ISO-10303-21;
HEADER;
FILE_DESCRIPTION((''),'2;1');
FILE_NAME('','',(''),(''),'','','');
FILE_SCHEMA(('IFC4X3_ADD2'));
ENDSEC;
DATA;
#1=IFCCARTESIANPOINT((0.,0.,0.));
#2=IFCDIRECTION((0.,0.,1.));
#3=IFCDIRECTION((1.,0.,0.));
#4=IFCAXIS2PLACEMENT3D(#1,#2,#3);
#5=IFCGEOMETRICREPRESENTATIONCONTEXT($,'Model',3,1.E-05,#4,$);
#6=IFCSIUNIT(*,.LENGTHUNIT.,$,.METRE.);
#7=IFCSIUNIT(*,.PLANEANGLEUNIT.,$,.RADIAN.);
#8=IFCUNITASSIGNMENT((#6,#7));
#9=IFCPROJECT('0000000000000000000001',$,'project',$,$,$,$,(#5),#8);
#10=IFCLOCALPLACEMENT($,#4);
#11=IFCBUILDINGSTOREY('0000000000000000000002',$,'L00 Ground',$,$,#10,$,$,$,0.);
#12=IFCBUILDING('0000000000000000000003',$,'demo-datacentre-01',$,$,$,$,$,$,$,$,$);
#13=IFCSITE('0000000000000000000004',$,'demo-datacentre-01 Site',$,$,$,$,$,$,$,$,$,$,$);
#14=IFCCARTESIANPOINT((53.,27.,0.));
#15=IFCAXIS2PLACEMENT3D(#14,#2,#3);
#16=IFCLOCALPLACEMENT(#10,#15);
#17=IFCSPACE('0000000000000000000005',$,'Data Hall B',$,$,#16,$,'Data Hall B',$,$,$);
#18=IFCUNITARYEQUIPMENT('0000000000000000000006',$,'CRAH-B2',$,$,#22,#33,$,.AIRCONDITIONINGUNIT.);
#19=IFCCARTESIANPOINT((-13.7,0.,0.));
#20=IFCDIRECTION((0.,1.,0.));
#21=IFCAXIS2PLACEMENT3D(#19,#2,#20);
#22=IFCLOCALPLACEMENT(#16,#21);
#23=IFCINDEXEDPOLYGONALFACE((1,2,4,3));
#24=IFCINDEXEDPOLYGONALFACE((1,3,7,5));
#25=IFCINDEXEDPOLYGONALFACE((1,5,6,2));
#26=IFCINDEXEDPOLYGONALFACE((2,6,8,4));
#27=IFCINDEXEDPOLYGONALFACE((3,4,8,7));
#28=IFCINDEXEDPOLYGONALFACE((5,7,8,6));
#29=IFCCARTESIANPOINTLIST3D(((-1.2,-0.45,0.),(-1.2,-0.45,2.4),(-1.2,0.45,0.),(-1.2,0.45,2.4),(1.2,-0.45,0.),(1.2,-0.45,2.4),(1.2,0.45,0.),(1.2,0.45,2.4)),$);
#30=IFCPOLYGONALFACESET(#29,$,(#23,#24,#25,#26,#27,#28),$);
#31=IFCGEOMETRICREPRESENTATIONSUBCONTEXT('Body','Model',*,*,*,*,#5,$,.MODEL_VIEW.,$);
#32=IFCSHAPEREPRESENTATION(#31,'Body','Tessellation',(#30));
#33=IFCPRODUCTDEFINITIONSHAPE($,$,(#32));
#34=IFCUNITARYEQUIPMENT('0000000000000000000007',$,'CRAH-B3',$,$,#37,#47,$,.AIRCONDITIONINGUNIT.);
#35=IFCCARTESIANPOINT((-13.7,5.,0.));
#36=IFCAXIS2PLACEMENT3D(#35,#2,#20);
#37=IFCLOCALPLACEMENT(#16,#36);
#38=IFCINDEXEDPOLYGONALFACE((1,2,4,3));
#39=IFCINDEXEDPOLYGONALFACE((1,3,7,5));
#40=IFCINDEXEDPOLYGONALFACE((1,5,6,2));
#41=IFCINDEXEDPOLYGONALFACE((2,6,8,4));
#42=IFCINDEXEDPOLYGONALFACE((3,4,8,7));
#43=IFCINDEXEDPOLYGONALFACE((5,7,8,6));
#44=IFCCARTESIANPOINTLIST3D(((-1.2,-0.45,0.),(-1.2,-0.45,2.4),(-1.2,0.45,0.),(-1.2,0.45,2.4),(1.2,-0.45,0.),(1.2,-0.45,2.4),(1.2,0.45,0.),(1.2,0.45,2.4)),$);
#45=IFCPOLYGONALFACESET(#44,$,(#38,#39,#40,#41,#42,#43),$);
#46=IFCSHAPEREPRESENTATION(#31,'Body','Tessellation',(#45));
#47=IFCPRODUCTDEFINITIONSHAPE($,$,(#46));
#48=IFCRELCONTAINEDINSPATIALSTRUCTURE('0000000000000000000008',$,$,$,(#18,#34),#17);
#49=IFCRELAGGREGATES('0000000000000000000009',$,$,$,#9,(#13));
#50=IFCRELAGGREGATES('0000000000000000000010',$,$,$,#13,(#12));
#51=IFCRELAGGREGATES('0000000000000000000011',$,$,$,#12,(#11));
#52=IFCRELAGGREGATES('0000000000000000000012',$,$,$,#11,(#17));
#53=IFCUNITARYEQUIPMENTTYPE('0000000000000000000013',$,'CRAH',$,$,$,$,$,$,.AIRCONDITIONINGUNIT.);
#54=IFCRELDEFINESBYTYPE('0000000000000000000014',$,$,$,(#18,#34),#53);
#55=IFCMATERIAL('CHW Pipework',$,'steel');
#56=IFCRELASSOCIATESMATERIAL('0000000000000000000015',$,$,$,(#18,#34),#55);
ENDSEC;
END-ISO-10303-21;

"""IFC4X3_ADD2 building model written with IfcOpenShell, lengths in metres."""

from ifc_helpers import new_model, si_unit, frame, origin_with_axes, place, context, subcontext, project, spatial, rectangle, extrude, material, type_object, element, save


model = new_model("IFC4X3_ADD2")

# Units and contexts
model_context = context("Model", 3, precision=1e-05, world=origin_with_axes())
body_context = subcontext(model_context, "Body", "Model", "MODEL_VIEW")
ifc_project = project(units=[si_unit("LENGTHUNIT", "METRE"), si_unit("PLANEANGLEUNIT", "RADIAN")], contexts=[model_context])

# Site, building, storey
site = spatial("IfcSite", under=ifc_project, Name="demo-datacentre-01 Site")
building = spatial("IfcBuilding", under=site, Name="demo-datacentre-01")
storey_placement = place(None, origin_with_axes())
storey = spatial("IfcBuildingStorey", under=building, at=storey_placement, Name="L00 Ground", Elevation=0.0)

# Shared definitions
ifc_material = material(Name="CHW Pipework", Category="steel")

# Shared definitions
space_1_placement = place(storey_placement, frame((53.0, 27.0, 0.0), z_axis=(0.0, 0.0, 1.0), x_axis=(1.0, 0.0, 0.0)))
space_1 = spatial("IfcSpace", under=storey, at=space_1_placement, Name="Data Hall B", LongName="Data Hall B")

# Unitary equipment
unitary_equipment_type = type_object("IfcUnitaryEquipmentType", Name="CRAH", PredefinedType="AIRCONDITIONINGUNIT")
for number, where, z_axis, x_axis, name in (
    (1, (-13.7, 0.0, 0.0), (0.0, 0.0, 1.0), (0.0, 1.0, 0.0), "CRAH-B2"),
    (2, (-13.7, 5.0, 0.0), (0.0, 0.0, 1.0), (0.0, 1.0, 0.0), "CRAH-B3"),
):
    element("IfcUnitaryEquipment", number, at=place(space_1_placement, frame(where, z_axis=z_axis, x_axis=x_axis)), inside=space_1, type_object=unitary_equipment_type, material=ifc_material, Name=name, PredefinedType="AIRCONDITIONINGUNIT", context=body_context, shape_type="SweptSolid", body=[
        extrude(rectangle(XDim=2.4, YDim=0.9), origin_with_axes(), (0.0, 0.0, 1.0), 2.4),
    ])

save(model, "model.ifc")
